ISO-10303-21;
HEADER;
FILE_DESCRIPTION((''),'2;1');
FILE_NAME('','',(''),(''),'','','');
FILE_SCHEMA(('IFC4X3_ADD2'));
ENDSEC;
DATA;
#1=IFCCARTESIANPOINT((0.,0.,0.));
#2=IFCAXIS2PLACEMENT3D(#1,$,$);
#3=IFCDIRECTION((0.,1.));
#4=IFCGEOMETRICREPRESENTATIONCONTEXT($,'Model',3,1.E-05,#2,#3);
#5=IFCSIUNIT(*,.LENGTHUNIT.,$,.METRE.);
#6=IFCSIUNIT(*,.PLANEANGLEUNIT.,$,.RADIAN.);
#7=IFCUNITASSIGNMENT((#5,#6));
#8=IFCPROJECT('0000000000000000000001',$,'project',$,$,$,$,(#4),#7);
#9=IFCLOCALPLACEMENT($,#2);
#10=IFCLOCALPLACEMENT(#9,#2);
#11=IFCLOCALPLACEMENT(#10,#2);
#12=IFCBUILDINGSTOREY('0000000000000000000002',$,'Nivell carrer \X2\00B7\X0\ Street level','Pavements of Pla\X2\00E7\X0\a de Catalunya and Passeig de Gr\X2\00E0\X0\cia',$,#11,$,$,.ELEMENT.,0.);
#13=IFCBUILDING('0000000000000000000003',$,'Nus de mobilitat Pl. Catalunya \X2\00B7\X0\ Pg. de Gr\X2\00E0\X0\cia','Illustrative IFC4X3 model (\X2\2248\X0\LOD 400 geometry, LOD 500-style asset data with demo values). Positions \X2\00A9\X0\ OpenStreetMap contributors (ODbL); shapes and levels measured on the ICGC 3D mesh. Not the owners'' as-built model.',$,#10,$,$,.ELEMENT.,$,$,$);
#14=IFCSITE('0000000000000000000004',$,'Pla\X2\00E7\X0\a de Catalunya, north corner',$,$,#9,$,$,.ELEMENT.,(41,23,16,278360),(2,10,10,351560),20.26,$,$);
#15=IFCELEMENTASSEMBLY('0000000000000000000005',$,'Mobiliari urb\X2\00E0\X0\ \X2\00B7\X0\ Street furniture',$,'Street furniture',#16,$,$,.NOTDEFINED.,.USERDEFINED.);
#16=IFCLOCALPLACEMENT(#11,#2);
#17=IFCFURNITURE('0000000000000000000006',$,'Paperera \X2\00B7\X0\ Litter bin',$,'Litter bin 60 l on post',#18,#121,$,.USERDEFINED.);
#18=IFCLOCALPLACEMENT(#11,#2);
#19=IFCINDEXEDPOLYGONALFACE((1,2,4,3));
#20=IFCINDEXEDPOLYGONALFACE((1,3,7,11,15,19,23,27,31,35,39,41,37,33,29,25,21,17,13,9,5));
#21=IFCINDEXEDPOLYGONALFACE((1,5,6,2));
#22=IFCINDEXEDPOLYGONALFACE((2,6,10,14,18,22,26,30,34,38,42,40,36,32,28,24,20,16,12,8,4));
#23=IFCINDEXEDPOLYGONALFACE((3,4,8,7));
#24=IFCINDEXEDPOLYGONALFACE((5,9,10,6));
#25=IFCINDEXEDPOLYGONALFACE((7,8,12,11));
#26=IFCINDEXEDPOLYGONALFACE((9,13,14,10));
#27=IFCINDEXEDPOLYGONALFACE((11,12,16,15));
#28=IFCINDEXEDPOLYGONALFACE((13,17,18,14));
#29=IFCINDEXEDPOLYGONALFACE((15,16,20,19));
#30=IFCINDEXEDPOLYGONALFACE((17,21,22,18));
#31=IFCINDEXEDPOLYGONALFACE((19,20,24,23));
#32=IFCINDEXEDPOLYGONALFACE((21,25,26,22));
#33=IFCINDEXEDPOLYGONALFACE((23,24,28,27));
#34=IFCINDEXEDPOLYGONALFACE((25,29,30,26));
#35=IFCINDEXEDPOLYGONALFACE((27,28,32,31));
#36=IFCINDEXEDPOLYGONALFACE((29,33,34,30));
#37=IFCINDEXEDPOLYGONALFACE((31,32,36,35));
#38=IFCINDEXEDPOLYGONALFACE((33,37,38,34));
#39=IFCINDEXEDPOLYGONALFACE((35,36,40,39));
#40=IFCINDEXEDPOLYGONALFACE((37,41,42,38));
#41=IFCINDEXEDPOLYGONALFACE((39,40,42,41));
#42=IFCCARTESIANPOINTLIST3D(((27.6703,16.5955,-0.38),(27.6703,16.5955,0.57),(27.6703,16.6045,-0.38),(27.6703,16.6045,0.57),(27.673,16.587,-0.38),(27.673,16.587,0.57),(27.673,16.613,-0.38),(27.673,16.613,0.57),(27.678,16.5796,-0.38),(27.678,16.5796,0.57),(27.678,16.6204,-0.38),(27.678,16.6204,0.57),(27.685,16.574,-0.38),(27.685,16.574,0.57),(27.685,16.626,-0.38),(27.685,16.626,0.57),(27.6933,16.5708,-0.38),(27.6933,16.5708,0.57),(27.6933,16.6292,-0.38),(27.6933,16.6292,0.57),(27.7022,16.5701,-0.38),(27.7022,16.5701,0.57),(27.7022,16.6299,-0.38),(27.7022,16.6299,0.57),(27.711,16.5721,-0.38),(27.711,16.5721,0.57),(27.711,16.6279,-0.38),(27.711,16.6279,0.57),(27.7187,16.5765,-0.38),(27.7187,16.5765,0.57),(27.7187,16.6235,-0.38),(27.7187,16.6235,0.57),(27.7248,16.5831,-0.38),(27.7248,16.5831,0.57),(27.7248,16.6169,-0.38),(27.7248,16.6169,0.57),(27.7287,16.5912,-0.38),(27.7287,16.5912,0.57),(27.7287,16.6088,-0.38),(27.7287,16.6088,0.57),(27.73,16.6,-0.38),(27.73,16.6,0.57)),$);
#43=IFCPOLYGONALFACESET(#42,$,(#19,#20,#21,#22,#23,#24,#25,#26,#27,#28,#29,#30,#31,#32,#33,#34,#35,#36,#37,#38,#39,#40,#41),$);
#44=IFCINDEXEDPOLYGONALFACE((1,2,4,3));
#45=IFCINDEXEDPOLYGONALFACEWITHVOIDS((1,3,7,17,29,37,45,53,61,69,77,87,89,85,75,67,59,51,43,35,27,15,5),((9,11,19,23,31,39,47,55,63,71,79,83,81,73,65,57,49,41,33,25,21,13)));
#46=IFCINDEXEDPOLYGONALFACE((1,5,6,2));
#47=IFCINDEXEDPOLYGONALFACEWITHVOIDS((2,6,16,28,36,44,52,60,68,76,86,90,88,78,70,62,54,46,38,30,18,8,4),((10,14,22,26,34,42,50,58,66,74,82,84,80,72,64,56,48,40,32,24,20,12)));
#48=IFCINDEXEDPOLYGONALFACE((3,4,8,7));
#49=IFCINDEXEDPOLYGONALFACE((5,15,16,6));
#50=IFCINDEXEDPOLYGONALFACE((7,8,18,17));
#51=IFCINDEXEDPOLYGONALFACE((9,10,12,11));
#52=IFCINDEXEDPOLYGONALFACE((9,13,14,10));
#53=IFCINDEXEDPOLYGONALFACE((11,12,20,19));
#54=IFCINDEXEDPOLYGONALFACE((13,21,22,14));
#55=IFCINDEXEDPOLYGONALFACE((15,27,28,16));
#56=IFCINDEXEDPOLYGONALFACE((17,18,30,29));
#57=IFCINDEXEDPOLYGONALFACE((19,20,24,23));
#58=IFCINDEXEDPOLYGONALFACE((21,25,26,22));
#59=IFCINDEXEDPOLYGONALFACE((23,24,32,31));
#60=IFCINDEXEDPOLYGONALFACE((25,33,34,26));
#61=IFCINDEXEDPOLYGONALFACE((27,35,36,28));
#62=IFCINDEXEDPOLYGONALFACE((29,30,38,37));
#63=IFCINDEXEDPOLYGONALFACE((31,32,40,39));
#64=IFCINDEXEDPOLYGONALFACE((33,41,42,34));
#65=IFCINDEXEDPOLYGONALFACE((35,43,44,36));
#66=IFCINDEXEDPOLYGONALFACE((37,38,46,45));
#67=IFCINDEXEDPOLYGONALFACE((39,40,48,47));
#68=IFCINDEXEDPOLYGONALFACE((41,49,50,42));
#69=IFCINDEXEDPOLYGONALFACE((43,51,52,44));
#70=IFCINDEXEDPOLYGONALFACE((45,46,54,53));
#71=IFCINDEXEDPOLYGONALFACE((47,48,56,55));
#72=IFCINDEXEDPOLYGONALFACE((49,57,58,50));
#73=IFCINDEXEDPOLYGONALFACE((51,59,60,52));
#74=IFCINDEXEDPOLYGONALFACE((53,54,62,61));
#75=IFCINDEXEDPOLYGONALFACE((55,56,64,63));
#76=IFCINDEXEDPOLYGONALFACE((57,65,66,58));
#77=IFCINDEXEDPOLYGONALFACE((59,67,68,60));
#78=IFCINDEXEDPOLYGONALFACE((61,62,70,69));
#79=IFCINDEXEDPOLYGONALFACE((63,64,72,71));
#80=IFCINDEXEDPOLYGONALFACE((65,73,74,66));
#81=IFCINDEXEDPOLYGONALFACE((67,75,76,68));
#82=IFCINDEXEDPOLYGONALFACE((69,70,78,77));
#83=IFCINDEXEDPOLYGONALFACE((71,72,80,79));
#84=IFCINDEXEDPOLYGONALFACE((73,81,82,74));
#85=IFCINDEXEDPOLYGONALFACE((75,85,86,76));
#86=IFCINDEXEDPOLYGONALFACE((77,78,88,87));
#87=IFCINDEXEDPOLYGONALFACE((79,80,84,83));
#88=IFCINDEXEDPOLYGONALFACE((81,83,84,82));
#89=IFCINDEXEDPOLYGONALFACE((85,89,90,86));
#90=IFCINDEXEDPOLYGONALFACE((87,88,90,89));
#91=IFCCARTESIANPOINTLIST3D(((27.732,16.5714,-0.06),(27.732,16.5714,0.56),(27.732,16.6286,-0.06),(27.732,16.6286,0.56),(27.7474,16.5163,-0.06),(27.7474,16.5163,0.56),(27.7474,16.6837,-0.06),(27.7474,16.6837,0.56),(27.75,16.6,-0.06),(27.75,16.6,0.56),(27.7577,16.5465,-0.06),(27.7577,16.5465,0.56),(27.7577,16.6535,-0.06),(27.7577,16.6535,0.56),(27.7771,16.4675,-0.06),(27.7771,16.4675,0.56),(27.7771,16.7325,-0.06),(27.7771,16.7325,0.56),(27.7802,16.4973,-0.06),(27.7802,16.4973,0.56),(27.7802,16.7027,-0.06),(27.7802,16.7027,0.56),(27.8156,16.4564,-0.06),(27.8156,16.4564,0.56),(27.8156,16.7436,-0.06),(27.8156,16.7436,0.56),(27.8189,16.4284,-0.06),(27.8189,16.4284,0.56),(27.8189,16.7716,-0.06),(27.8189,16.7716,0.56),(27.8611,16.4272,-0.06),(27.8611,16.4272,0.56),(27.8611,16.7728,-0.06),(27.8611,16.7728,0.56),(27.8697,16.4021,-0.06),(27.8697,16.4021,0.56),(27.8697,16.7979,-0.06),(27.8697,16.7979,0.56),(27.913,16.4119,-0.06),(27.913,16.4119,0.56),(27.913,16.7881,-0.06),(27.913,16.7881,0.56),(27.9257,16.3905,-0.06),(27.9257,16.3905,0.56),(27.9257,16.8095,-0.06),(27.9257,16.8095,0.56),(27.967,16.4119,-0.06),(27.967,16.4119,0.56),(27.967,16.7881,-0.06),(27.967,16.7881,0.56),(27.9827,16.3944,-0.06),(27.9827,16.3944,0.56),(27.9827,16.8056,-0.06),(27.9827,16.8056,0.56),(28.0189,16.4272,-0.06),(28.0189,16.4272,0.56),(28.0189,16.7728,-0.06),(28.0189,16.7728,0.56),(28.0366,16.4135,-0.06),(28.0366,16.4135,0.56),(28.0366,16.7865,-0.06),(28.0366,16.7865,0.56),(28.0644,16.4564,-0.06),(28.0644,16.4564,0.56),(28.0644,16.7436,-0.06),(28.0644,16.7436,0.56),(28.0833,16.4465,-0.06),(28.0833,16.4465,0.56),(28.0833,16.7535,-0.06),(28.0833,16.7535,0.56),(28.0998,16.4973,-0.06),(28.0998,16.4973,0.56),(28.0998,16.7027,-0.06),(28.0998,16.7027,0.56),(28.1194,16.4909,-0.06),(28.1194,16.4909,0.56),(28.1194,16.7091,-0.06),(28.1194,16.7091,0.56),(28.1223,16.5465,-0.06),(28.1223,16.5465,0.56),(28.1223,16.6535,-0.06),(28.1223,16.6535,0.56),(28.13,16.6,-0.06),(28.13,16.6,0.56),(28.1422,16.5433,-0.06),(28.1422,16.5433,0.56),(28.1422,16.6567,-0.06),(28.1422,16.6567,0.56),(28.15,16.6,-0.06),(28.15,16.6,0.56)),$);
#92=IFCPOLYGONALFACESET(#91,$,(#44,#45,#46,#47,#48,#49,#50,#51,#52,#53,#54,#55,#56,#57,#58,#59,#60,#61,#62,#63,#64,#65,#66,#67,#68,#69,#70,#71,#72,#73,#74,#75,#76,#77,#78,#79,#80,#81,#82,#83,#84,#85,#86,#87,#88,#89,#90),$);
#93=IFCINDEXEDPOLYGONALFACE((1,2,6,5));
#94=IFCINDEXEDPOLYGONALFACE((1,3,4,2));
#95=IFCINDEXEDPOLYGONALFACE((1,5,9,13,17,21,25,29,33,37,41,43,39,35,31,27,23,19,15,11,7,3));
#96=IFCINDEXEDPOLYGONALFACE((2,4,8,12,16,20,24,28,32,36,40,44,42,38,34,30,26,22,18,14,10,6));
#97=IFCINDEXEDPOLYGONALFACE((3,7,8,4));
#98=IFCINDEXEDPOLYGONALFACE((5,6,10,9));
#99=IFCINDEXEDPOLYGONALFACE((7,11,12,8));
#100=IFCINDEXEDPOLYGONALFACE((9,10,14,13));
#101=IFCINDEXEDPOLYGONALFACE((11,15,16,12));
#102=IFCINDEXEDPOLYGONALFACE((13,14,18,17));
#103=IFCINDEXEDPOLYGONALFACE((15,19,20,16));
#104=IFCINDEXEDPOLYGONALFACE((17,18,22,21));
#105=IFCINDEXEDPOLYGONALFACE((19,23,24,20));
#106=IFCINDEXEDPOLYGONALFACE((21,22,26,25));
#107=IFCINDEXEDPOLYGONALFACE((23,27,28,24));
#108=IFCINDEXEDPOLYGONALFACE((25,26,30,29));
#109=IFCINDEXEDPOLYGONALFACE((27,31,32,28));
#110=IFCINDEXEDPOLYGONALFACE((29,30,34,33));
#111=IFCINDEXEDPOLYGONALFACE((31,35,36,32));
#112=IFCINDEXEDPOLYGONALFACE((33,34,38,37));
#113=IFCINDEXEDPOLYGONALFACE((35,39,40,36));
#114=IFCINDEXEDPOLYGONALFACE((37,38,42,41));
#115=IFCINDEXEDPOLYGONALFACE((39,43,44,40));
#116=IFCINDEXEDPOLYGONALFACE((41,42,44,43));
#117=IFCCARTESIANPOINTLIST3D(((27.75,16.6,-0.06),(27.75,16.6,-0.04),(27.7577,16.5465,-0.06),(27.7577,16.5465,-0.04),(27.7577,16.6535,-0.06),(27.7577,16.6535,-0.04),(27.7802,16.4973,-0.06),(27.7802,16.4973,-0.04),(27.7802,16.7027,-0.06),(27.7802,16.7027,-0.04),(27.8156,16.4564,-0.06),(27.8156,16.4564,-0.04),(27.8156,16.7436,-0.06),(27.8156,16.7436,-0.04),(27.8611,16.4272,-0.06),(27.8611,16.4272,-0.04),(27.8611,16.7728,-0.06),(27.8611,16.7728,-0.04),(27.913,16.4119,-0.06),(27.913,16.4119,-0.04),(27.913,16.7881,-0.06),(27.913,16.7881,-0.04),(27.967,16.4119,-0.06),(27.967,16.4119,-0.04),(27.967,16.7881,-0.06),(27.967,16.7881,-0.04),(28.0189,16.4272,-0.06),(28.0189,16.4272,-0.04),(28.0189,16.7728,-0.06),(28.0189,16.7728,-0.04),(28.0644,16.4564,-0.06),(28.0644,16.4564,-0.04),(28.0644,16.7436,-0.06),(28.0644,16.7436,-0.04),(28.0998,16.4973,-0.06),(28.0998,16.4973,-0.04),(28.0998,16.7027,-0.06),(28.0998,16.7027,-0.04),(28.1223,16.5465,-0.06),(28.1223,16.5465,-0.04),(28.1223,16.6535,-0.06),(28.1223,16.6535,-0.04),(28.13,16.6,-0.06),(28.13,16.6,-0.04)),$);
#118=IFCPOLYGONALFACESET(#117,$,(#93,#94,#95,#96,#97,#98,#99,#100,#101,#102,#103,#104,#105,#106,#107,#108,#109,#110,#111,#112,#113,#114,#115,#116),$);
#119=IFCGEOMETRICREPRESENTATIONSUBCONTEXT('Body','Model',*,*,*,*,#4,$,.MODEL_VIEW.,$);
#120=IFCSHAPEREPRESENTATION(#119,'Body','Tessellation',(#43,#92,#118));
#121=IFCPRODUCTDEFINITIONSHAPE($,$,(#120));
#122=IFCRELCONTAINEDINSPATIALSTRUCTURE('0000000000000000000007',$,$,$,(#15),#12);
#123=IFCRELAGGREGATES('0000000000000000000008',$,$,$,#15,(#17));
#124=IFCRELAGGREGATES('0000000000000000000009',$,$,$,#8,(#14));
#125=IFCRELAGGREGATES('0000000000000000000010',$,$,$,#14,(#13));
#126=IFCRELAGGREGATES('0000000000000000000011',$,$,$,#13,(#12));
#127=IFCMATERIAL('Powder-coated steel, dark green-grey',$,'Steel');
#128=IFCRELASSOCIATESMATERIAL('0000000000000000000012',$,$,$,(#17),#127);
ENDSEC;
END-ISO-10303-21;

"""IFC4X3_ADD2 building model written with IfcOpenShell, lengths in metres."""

from ifc_helpers import new_model, si_unit, direction, frame, origin, origin_2d_with_axis, place, context, subcontext, project, spatial, circle, hollow_circle, extrude, material, element, aggregate, save


model = new_model("IFC4X3_ADD2")

# Units and contexts
model_context = context("Model", 3, precision=1e-05, world=origin(), true_north=direction((0.0, 1.0)))
body_context = subcontext(model_context, "Body", "Model", "MODEL_VIEW")
ifc_project = project(units=[si_unit("LENGTHUNIT", "METRE"), si_unit("PLANEANGLEUNIT", "RADIAN")], contexts=[model_context])

# Site, building, storey
site_placement = place(None, origin())
site = spatial("IfcSite", under=ifc_project, at=site_placement, Name="Plaça de Catalunya, north corner", CompositionType="ELEMENT", RefLatitude=(41, 23, 16, 278360), RefLongitude=(2, 10, 10, 351560), RefElevation=20.26)
building_placement = place(site_placement, origin())
building = spatial("IfcBuilding", under=site, at=building_placement, Name="Nus de mobilitat Pl. Catalunya · Pg. de Gràcia", Description="Illustrative IFC4X3 model (≈LOD 400 geometry, LOD 500-style asset data with demo values). Positions © OpenStreetMap contributors (ODbL); shapes and levels measured on the ICGC 3D mesh. Not the owners' as-built model.", CompositionType="ELEMENT")
storey_placement = place(building_placement, origin())
storey = spatial("IfcBuildingStorey", under=building, at=storey_placement, Name="Nivell carrer · Street level", Description="Pavements of Plaça de Catalunya and Passeig de Gràcia", CompositionType="ELEMENT", Elevation=0.0)

# Element assembly
assembly_1_placement = place(building_placement, origin())
assembly_1 = element("IfcElementAssembly", 1, at=assembly_1_placement, inside=storey, Name="Mobiliari urbà · Street furniture", ObjectType="Street furniture", AssemblyPlace="NOTDEFINED", PredefinedType="USERDEFINED")

# Furniture
ifc_material_1 = material(Name="Powder-coated steel, dark green-grey", Category="Steel")
furniture_placement = place(building_placement, origin())
furniture = element("IfcFurniture", 2, at=furniture_placement, material=ifc_material_1, Name="Paperera · Litter bin", ObjectType="Litter bin 60 l on post", PredefinedType="USERDEFINED", context=body_context, shape_type="SweptSolid", body=[
    extrude(circle(Radius=0.03, at=origin_2d_with_axis()), frame((27.7, 16.6, -0.38)), (0.0, 0.0, 1.0), 0.95),
    extrude(hollow_circle(Radius=0.21, WallThickness=0.02, at=origin_2d_with_axis()), frame((27.94, 16.6, -0.06)), (0.0, 0.0, 1.0), 0.62),
    extrude(circle(Radius=0.19, at=origin_2d_with_axis()), frame((27.94, 16.6, -0.06)), (0.0, 0.0, 1.0), 0.02),
])

aggregate(assembly_1, [furniture])

save(model, "model.ifc")
